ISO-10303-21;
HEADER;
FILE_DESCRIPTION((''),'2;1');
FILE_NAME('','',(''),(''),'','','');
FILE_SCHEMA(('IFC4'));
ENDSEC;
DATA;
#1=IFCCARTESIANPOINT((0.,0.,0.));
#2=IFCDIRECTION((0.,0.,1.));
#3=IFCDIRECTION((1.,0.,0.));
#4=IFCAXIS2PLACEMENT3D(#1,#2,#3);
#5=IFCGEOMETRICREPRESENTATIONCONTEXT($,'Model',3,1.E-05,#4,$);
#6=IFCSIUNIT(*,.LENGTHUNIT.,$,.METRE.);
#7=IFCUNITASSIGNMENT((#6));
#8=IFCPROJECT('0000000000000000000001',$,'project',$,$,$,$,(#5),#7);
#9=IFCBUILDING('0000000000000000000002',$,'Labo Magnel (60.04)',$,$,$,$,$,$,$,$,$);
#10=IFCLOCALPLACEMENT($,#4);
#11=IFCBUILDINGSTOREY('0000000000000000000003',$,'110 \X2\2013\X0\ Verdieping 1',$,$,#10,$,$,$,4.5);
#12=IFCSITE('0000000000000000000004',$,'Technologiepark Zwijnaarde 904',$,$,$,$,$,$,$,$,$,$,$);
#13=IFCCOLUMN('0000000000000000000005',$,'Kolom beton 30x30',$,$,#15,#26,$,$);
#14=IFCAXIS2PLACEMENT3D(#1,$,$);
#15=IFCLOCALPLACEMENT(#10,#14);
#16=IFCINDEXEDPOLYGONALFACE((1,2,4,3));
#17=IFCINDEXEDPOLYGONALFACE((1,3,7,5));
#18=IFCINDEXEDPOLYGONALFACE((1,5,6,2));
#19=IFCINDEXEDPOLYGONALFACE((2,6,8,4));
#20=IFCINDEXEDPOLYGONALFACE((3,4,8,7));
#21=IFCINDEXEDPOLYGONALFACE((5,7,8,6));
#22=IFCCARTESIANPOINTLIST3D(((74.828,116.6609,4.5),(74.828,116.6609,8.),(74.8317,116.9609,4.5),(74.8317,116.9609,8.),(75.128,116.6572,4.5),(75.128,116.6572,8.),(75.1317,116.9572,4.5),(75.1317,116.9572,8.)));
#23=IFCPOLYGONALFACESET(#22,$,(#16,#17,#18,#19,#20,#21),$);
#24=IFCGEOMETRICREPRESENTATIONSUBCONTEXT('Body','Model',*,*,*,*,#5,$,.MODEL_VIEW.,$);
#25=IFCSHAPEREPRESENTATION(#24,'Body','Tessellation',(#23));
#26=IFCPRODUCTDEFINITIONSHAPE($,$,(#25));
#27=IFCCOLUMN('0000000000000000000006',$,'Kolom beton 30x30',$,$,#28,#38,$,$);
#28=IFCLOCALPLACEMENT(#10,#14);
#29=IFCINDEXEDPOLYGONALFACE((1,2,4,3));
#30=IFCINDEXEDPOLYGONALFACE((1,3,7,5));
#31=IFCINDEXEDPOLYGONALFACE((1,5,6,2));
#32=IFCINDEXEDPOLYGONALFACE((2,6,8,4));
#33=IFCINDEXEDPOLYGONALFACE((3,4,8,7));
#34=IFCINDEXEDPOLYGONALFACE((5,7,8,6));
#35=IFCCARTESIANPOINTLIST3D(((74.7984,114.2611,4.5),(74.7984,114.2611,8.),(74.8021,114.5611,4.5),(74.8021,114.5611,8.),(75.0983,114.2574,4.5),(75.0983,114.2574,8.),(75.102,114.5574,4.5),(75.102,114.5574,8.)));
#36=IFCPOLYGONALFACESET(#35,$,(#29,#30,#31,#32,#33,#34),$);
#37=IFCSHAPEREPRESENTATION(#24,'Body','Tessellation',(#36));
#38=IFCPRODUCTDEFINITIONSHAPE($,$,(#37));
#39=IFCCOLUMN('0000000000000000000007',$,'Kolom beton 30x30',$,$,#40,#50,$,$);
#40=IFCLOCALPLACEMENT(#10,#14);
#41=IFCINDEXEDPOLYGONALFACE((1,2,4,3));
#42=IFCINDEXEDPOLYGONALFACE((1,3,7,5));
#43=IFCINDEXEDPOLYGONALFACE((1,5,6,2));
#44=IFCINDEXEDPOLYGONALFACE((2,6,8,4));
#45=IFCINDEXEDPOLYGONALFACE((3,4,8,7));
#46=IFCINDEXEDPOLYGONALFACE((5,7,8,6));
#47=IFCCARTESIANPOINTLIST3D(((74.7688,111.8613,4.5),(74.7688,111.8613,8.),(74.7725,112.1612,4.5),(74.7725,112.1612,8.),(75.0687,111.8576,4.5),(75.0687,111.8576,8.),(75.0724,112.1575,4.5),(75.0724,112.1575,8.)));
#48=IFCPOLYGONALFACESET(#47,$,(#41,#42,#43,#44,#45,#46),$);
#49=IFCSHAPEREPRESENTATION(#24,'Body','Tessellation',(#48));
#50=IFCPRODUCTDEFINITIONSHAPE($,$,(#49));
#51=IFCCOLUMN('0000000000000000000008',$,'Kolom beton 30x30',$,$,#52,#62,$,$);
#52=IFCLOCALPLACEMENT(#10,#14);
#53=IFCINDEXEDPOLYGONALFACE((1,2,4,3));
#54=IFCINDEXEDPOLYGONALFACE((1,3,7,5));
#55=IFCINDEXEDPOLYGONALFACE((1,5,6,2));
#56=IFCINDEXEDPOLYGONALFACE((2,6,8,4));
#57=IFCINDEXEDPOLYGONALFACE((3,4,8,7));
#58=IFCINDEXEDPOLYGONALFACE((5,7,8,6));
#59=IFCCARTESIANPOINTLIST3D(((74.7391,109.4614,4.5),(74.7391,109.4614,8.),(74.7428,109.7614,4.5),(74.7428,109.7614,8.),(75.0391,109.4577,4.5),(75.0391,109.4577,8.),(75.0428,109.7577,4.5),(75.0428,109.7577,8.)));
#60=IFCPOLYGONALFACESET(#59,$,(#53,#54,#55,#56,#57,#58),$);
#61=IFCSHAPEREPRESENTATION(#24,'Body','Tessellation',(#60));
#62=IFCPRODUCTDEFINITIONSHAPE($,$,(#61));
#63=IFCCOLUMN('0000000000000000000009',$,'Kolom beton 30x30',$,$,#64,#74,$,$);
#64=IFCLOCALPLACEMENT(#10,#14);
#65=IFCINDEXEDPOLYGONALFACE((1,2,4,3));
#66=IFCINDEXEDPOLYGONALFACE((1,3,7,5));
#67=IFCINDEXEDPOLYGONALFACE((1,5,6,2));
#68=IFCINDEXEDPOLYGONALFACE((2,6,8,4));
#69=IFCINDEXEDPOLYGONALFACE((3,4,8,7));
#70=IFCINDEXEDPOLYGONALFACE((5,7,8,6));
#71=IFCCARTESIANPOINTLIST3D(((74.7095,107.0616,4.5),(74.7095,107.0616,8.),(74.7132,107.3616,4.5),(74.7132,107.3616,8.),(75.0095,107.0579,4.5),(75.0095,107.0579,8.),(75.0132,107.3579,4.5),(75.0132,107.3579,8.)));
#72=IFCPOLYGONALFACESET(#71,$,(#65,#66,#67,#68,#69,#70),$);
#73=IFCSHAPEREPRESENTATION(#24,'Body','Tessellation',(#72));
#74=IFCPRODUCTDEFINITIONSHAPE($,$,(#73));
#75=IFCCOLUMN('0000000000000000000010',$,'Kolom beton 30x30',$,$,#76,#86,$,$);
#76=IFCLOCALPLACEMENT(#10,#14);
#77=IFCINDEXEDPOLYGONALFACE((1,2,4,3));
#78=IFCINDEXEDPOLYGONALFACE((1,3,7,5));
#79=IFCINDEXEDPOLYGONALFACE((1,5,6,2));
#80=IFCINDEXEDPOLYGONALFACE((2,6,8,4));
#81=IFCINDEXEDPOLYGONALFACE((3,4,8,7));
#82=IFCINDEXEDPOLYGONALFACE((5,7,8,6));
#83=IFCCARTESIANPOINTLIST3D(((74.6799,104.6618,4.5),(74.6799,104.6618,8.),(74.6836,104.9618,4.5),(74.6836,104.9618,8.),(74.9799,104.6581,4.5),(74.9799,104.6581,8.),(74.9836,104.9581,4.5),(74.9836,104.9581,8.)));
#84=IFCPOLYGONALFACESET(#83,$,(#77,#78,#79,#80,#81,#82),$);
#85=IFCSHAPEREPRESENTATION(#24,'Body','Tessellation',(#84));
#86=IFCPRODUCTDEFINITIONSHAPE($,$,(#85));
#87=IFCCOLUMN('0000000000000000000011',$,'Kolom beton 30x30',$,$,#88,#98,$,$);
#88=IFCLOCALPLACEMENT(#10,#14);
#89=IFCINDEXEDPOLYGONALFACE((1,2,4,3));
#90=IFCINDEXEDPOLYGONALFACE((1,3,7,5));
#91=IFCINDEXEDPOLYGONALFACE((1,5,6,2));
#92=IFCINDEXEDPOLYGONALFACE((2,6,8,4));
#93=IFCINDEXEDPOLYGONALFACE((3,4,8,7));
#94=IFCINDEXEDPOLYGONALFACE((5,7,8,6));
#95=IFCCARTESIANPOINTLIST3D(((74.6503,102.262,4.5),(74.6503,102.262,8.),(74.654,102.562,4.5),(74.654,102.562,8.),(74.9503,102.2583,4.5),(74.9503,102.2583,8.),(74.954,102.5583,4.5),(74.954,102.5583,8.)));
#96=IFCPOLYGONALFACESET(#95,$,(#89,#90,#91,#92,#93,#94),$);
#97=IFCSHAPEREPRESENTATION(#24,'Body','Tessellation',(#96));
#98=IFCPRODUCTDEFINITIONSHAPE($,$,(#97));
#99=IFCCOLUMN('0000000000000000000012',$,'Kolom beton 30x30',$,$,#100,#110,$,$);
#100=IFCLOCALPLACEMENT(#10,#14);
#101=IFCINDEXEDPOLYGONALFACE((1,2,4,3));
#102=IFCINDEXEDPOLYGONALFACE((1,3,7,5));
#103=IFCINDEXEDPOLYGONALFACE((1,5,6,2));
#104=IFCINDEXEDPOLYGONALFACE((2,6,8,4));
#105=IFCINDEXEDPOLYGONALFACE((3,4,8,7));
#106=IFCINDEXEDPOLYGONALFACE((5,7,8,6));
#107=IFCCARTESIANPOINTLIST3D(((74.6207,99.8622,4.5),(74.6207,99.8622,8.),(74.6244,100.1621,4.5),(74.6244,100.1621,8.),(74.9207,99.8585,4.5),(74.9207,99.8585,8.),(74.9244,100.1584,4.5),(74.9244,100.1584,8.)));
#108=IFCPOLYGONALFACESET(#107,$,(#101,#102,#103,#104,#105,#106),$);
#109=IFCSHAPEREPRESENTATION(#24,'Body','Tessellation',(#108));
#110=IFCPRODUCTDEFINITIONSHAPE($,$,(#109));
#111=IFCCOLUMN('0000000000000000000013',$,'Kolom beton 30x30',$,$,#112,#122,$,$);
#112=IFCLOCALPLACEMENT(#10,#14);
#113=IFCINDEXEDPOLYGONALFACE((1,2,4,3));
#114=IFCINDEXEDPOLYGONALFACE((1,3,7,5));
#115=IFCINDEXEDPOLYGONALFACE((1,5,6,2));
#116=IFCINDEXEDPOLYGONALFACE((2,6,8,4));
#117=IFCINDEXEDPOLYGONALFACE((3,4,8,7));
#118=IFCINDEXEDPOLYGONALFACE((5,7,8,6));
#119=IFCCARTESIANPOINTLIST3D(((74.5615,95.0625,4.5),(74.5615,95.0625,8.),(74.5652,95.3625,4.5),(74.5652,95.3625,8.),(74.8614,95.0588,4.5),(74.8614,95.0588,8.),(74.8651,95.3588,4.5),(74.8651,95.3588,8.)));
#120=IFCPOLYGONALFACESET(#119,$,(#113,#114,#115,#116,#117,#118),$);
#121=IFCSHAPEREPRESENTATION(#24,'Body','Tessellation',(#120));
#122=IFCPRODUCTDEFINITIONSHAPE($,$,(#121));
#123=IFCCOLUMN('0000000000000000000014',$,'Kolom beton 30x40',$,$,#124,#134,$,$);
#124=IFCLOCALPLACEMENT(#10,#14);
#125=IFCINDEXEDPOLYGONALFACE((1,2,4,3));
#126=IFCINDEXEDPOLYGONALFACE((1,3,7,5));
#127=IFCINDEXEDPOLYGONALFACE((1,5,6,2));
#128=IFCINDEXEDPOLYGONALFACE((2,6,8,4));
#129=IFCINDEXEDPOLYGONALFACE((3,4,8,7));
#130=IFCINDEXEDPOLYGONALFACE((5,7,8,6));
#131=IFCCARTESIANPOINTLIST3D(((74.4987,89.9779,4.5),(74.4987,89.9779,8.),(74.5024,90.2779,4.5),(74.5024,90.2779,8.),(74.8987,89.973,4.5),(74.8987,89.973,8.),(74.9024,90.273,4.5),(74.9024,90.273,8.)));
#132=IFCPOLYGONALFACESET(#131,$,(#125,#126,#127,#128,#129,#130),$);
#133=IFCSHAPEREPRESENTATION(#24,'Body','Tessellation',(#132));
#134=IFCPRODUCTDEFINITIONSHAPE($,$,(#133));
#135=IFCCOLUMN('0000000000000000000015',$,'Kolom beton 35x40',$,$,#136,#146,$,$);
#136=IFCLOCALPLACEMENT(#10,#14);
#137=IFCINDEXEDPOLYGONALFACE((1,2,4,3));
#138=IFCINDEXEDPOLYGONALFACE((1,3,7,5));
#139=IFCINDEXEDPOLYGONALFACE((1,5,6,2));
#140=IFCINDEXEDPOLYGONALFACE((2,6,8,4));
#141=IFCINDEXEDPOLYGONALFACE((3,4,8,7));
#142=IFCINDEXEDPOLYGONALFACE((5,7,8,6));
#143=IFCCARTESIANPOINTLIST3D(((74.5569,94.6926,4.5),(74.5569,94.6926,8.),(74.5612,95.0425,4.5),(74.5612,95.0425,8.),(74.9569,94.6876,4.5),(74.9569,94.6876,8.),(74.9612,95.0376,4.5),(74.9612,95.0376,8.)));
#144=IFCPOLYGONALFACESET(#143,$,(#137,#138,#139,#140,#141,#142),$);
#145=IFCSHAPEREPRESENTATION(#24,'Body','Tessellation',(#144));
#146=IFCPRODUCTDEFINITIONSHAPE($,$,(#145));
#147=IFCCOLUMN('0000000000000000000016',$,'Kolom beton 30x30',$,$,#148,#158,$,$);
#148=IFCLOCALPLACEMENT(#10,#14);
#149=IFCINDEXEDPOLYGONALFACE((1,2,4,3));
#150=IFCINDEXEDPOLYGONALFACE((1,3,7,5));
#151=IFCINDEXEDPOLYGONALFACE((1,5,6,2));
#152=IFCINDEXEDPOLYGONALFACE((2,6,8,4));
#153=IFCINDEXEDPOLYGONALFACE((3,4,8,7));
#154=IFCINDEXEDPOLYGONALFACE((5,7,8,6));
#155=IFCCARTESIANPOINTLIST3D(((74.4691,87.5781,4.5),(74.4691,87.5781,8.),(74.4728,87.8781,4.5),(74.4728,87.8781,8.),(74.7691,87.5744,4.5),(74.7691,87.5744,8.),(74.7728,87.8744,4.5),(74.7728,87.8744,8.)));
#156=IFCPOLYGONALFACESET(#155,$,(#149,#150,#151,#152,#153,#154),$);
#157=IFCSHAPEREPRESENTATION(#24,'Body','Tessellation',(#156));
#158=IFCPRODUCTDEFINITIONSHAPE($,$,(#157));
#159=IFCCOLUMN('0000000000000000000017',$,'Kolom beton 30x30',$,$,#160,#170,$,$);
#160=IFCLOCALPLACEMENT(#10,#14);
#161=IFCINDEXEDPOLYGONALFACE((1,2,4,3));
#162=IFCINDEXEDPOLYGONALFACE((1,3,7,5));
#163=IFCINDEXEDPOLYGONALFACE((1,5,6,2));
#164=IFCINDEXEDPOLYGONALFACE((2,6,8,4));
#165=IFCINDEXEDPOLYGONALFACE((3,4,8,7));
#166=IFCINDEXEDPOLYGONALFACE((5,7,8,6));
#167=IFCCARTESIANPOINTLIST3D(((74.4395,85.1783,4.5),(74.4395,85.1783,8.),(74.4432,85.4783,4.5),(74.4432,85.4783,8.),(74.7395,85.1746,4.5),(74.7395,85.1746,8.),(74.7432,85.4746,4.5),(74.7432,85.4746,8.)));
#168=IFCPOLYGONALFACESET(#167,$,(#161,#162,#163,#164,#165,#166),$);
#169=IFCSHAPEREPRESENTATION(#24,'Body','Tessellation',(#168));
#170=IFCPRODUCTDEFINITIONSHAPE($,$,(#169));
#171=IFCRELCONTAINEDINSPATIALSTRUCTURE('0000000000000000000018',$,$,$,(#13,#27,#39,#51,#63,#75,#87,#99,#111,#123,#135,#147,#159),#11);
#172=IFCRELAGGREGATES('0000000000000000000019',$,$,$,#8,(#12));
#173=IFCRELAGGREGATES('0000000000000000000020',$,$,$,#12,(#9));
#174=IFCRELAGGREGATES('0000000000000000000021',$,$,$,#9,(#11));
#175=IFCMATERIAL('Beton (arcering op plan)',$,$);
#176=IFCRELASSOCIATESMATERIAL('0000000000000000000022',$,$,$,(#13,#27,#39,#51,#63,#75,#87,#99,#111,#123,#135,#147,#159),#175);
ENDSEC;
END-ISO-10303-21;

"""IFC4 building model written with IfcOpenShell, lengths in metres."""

from ifc_helpers import new_model, si_unit, frame, origin, origin_with_axes, place, context, subcontext, project, spatial, polyline, outline, extrude, material, element, save


model = new_model("IFC4")

# Units and contexts
model_context = context("Model", 3, precision=1e-05, world=origin_with_axes())
body_context = subcontext(model_context, "Body", "Model", "MODEL_VIEW")
ifc_project = project(units=[si_unit("LENGTHUNIT", "METRE")], contexts=[model_context])

# Site, building, storey
site = spatial("IfcSite", under=ifc_project, Name="Technologiepark Zwijnaarde 904")
building = spatial("IfcBuilding", under=site, Name="Labo Magnel (60.04)")
storey_placement = place(None, origin_with_axes())
storey = spatial("IfcBuildingStorey", under=building, at=storey_placement, Name="110 – Verdieping 1", Elevation=4.5)

# Columns
ifc_material = material(Name="Beton (arcering op plan)")
column_1_placement = place(storey_placement, frame((0.0, 0.0, 4.5), z_axis=(0.0, 0.0, 1.0), x_axis=(1.0, 0.0, 0.0)))
element("IfcColumn", 1, at=column_1_placement, inside=storey, material=ifc_material, Name="Kolom beton 30x30", context=body_context, shape_type="SweptSolid", body=[
    extrude(outline(polyline([(75.1317, 116.9572), (74.8317, 116.9609), (74.828, 116.6609), (75.128, 116.6572), (75.1317, 116.9572)])), origin(), (0.0, 0.0, 1.0), 3.5),
])
column_2_placement = place(storey_placement, frame((0.0, 0.0, 4.5), z_axis=(0.0, 0.0, 1.0), x_axis=(1.0, 0.0, 0.0)))
element("IfcColumn", 2, at=column_2_placement, inside=storey, material=ifc_material, Name="Kolom beton 30x30", context=body_context, shape_type="SweptSolid", body=[
    extrude(outline(polyline([(75.102, 114.5574), (74.8021, 114.5611), (74.7984, 114.2611), (75.0983, 114.2574), (75.102, 114.5574)])), origin(), (0.0, 0.0, 1.0), 3.5),
])
column_3_placement = place(storey_placement, frame((0.0, 0.0, 4.5), z_axis=(0.0, 0.0, 1.0), x_axis=(1.0, 0.0, 0.0)))
element("IfcColumn", 3, at=column_3_placement, inside=storey, material=ifc_material, Name="Kolom beton 30x30", context=body_context, shape_type="SweptSolid", body=[
    extrude(outline(polyline([(75.0724, 112.1575), (74.7725, 112.1612), (74.7688, 111.8613), (75.0687, 111.8576), (75.0724, 112.1575)])), origin(), (0.0, 0.0, 1.0), 3.5),
])
column_4_placement = place(storey_placement, frame((0.0, 0.0, 4.5), z_axis=(0.0, 0.0, 1.0), x_axis=(1.0, 0.0, 0.0)))
element("IfcColumn", 4, at=column_4_placement, inside=storey, material=ifc_material, Name="Kolom beton 30x30", context=body_context, shape_type="SweptSolid", body=[
    extrude(outline(polyline([(75.0428, 109.7577), (74.7428, 109.7614), (74.7391, 109.4614), (75.0391, 109.4577), (75.0428, 109.7577)])), origin(), (0.0, 0.0, 1.0), 3.5),
])
column_5_placement = place(storey_placement, frame((0.0, 0.0, 4.5), z_axis=(0.0, 0.0, 1.0), x_axis=(1.0, 0.0, 0.0)))
element("IfcColumn", 5, at=column_5_placement, inside=storey, material=ifc_material, Name="Kolom beton 30x30", context=body_context, shape_type="SweptSolid", body=[
    extrude(outline(polyline([(75.0132, 107.3579), (74.7132, 107.3616), (74.7095, 107.0616), (75.0095, 107.0579), (75.0132, 107.3579)])), origin(), (0.0, 0.0, 1.0), 3.5),
])
column_6_placement = place(storey_placement, frame((0.0, 0.0, 4.5), z_axis=(0.0, 0.0, 1.0), x_axis=(1.0, 0.0, 0.0)))
element("IfcColumn", 6, at=column_6_placement, inside=storey, material=ifc_material, Name="Kolom beton 30x30", context=body_context, shape_type="SweptSolid", body=[
    extrude(outline(polyline([(74.9836, 104.9581), (74.6836, 104.9618), (74.6799, 104.6618), (74.9799, 104.6581), (74.9836, 104.9581)])), origin(), (0.0, 0.0, 1.0), 3.5),
])
column_7_placement = place(storey_placement, frame((0.0, 0.0, 4.5), z_axis=(0.0, 0.0, 1.0), x_axis=(1.0, 0.0, 0.0)))
element("IfcColumn", 7, at=column_7_placement, inside=storey, material=ifc_material, Name="Kolom beton 30x30", context=body_context, shape_type="SweptSolid", body=[
    extrude(outline(polyline([(74.954, 102.5583), (74.654, 102.562), (74.6503, 102.262), (74.9503, 102.2583), (74.954, 102.5583)])), origin(), (0.0, 0.0, 1.0), 3.5),
])
column_8_placement = place(storey_placement, frame((0.0, 0.0, 4.5), z_axis=(0.0, 0.0, 1.0), x_axis=(1.0, 0.0, 0.0)))
element("IfcColumn", 8, at=column_8_placement, inside=storey, material=ifc_material, Name="Kolom beton 30x30", context=body_context, shape_type="SweptSolid", body=[
    extrude(outline(polyline([(74.9244, 100.1584), (74.6244, 100.1621), (74.6207, 99.8622), (74.9207, 99.8585), (74.9244, 100.1584)])), origin(), (0.0, 0.0, 1.0), 3.5),
])
column_9_placement = place(storey_placement, frame((0.0, 0.0, 4.5), z_axis=(0.0, 0.0, 1.0), x_axis=(1.0, 0.0, 0.0)))
element("IfcColumn", 9, at=column_9_placement, inside=storey, material=ifc_material, Name="Kolom beton 30x30", context=body_context, shape_type="SweptSolid", body=[
    extrude(outline(polyline([(74.8651, 95.3588), (74.5652, 95.3625), (74.5615, 95.0625), (74.8614, 95.0588), (74.8651, 95.3588)])), origin(), (0.0, 0.0, 1.0), 3.5),
])
column_10_placement = place(storey_placement, frame((0.0, 0.0, 4.5), z_axis=(0.0, 0.0, 1.0), x_axis=(1.0, 0.0, 0.0)))
element("IfcColumn", 10, at=column_10_placement, inside=storey, material=ifc_material, Name="Kolom beton 30x40", context=body_context, shape_type="SweptSolid", body=[
    extrude(outline(polyline([(74.9024, 90.273), (74.5024, 90.2779), (74.4987, 89.9779), (74.8987, 89.973), (74.9024, 90.273)])), origin(), (0.0, 0.0, 1.0), 3.5),
])
column_11_placement = place(storey_placement, frame((0.0, 0.0, 4.5), z_axis=(0.0, 0.0, 1.0), x_axis=(1.0, 0.0, 0.0)))
element("IfcColumn", 11, at=column_11_placement, inside=storey, material=ifc_material, Name="Kolom beton 35x40", context=body_context, shape_type="SweptSolid", body=[
    extrude(outline(polyline([(74.9612, 95.0376), (74.5612, 95.0425), (74.5569, 94.6926), (74.9569, 94.6876), (74.9612, 95.0376)])), origin(), (0.0, 0.0, 1.0), 3.5),
])
column_12_placement = place(storey_placement, frame((0.0, 0.0, 4.5), z_axis=(0.0, 0.0, 1.0), x_axis=(1.0, 0.0, 0.0)))
element("IfcColumn", 12, at=column_12_placement, inside=storey, material=ifc_material, Name="Kolom beton 30x30", context=body_context, shape_type="SweptSolid", body=[
    extrude(outline(polyline([(74.7728, 87.8744), (74.4728, 87.8781), (74.4691, 87.5781), (74.7691, 87.5744), (74.7728, 87.8744)])), origin(), (0.0, 0.0, 1.0), 3.5),
])
column_13_placement = place(storey_placement, frame((0.0, 0.0, 4.5), z_axis=(0.0, 0.0, 1.0), x_axis=(1.0, 0.0, 0.0)))
element("IfcColumn", 13, at=column_13_placement, inside=storey, material=ifc_material, Name="Kolom beton 30x30", context=body_context, shape_type="SweptSolid", body=[
    extrude(outline(polyline([(74.7432, 85.4746), (74.4432, 85.4783), (74.4395, 85.1783), (74.7395, 85.1746), (74.7432, 85.4746)])), origin(), (0.0, 0.0, 1.0), 3.5),
])

save(model, "model.ifc")
